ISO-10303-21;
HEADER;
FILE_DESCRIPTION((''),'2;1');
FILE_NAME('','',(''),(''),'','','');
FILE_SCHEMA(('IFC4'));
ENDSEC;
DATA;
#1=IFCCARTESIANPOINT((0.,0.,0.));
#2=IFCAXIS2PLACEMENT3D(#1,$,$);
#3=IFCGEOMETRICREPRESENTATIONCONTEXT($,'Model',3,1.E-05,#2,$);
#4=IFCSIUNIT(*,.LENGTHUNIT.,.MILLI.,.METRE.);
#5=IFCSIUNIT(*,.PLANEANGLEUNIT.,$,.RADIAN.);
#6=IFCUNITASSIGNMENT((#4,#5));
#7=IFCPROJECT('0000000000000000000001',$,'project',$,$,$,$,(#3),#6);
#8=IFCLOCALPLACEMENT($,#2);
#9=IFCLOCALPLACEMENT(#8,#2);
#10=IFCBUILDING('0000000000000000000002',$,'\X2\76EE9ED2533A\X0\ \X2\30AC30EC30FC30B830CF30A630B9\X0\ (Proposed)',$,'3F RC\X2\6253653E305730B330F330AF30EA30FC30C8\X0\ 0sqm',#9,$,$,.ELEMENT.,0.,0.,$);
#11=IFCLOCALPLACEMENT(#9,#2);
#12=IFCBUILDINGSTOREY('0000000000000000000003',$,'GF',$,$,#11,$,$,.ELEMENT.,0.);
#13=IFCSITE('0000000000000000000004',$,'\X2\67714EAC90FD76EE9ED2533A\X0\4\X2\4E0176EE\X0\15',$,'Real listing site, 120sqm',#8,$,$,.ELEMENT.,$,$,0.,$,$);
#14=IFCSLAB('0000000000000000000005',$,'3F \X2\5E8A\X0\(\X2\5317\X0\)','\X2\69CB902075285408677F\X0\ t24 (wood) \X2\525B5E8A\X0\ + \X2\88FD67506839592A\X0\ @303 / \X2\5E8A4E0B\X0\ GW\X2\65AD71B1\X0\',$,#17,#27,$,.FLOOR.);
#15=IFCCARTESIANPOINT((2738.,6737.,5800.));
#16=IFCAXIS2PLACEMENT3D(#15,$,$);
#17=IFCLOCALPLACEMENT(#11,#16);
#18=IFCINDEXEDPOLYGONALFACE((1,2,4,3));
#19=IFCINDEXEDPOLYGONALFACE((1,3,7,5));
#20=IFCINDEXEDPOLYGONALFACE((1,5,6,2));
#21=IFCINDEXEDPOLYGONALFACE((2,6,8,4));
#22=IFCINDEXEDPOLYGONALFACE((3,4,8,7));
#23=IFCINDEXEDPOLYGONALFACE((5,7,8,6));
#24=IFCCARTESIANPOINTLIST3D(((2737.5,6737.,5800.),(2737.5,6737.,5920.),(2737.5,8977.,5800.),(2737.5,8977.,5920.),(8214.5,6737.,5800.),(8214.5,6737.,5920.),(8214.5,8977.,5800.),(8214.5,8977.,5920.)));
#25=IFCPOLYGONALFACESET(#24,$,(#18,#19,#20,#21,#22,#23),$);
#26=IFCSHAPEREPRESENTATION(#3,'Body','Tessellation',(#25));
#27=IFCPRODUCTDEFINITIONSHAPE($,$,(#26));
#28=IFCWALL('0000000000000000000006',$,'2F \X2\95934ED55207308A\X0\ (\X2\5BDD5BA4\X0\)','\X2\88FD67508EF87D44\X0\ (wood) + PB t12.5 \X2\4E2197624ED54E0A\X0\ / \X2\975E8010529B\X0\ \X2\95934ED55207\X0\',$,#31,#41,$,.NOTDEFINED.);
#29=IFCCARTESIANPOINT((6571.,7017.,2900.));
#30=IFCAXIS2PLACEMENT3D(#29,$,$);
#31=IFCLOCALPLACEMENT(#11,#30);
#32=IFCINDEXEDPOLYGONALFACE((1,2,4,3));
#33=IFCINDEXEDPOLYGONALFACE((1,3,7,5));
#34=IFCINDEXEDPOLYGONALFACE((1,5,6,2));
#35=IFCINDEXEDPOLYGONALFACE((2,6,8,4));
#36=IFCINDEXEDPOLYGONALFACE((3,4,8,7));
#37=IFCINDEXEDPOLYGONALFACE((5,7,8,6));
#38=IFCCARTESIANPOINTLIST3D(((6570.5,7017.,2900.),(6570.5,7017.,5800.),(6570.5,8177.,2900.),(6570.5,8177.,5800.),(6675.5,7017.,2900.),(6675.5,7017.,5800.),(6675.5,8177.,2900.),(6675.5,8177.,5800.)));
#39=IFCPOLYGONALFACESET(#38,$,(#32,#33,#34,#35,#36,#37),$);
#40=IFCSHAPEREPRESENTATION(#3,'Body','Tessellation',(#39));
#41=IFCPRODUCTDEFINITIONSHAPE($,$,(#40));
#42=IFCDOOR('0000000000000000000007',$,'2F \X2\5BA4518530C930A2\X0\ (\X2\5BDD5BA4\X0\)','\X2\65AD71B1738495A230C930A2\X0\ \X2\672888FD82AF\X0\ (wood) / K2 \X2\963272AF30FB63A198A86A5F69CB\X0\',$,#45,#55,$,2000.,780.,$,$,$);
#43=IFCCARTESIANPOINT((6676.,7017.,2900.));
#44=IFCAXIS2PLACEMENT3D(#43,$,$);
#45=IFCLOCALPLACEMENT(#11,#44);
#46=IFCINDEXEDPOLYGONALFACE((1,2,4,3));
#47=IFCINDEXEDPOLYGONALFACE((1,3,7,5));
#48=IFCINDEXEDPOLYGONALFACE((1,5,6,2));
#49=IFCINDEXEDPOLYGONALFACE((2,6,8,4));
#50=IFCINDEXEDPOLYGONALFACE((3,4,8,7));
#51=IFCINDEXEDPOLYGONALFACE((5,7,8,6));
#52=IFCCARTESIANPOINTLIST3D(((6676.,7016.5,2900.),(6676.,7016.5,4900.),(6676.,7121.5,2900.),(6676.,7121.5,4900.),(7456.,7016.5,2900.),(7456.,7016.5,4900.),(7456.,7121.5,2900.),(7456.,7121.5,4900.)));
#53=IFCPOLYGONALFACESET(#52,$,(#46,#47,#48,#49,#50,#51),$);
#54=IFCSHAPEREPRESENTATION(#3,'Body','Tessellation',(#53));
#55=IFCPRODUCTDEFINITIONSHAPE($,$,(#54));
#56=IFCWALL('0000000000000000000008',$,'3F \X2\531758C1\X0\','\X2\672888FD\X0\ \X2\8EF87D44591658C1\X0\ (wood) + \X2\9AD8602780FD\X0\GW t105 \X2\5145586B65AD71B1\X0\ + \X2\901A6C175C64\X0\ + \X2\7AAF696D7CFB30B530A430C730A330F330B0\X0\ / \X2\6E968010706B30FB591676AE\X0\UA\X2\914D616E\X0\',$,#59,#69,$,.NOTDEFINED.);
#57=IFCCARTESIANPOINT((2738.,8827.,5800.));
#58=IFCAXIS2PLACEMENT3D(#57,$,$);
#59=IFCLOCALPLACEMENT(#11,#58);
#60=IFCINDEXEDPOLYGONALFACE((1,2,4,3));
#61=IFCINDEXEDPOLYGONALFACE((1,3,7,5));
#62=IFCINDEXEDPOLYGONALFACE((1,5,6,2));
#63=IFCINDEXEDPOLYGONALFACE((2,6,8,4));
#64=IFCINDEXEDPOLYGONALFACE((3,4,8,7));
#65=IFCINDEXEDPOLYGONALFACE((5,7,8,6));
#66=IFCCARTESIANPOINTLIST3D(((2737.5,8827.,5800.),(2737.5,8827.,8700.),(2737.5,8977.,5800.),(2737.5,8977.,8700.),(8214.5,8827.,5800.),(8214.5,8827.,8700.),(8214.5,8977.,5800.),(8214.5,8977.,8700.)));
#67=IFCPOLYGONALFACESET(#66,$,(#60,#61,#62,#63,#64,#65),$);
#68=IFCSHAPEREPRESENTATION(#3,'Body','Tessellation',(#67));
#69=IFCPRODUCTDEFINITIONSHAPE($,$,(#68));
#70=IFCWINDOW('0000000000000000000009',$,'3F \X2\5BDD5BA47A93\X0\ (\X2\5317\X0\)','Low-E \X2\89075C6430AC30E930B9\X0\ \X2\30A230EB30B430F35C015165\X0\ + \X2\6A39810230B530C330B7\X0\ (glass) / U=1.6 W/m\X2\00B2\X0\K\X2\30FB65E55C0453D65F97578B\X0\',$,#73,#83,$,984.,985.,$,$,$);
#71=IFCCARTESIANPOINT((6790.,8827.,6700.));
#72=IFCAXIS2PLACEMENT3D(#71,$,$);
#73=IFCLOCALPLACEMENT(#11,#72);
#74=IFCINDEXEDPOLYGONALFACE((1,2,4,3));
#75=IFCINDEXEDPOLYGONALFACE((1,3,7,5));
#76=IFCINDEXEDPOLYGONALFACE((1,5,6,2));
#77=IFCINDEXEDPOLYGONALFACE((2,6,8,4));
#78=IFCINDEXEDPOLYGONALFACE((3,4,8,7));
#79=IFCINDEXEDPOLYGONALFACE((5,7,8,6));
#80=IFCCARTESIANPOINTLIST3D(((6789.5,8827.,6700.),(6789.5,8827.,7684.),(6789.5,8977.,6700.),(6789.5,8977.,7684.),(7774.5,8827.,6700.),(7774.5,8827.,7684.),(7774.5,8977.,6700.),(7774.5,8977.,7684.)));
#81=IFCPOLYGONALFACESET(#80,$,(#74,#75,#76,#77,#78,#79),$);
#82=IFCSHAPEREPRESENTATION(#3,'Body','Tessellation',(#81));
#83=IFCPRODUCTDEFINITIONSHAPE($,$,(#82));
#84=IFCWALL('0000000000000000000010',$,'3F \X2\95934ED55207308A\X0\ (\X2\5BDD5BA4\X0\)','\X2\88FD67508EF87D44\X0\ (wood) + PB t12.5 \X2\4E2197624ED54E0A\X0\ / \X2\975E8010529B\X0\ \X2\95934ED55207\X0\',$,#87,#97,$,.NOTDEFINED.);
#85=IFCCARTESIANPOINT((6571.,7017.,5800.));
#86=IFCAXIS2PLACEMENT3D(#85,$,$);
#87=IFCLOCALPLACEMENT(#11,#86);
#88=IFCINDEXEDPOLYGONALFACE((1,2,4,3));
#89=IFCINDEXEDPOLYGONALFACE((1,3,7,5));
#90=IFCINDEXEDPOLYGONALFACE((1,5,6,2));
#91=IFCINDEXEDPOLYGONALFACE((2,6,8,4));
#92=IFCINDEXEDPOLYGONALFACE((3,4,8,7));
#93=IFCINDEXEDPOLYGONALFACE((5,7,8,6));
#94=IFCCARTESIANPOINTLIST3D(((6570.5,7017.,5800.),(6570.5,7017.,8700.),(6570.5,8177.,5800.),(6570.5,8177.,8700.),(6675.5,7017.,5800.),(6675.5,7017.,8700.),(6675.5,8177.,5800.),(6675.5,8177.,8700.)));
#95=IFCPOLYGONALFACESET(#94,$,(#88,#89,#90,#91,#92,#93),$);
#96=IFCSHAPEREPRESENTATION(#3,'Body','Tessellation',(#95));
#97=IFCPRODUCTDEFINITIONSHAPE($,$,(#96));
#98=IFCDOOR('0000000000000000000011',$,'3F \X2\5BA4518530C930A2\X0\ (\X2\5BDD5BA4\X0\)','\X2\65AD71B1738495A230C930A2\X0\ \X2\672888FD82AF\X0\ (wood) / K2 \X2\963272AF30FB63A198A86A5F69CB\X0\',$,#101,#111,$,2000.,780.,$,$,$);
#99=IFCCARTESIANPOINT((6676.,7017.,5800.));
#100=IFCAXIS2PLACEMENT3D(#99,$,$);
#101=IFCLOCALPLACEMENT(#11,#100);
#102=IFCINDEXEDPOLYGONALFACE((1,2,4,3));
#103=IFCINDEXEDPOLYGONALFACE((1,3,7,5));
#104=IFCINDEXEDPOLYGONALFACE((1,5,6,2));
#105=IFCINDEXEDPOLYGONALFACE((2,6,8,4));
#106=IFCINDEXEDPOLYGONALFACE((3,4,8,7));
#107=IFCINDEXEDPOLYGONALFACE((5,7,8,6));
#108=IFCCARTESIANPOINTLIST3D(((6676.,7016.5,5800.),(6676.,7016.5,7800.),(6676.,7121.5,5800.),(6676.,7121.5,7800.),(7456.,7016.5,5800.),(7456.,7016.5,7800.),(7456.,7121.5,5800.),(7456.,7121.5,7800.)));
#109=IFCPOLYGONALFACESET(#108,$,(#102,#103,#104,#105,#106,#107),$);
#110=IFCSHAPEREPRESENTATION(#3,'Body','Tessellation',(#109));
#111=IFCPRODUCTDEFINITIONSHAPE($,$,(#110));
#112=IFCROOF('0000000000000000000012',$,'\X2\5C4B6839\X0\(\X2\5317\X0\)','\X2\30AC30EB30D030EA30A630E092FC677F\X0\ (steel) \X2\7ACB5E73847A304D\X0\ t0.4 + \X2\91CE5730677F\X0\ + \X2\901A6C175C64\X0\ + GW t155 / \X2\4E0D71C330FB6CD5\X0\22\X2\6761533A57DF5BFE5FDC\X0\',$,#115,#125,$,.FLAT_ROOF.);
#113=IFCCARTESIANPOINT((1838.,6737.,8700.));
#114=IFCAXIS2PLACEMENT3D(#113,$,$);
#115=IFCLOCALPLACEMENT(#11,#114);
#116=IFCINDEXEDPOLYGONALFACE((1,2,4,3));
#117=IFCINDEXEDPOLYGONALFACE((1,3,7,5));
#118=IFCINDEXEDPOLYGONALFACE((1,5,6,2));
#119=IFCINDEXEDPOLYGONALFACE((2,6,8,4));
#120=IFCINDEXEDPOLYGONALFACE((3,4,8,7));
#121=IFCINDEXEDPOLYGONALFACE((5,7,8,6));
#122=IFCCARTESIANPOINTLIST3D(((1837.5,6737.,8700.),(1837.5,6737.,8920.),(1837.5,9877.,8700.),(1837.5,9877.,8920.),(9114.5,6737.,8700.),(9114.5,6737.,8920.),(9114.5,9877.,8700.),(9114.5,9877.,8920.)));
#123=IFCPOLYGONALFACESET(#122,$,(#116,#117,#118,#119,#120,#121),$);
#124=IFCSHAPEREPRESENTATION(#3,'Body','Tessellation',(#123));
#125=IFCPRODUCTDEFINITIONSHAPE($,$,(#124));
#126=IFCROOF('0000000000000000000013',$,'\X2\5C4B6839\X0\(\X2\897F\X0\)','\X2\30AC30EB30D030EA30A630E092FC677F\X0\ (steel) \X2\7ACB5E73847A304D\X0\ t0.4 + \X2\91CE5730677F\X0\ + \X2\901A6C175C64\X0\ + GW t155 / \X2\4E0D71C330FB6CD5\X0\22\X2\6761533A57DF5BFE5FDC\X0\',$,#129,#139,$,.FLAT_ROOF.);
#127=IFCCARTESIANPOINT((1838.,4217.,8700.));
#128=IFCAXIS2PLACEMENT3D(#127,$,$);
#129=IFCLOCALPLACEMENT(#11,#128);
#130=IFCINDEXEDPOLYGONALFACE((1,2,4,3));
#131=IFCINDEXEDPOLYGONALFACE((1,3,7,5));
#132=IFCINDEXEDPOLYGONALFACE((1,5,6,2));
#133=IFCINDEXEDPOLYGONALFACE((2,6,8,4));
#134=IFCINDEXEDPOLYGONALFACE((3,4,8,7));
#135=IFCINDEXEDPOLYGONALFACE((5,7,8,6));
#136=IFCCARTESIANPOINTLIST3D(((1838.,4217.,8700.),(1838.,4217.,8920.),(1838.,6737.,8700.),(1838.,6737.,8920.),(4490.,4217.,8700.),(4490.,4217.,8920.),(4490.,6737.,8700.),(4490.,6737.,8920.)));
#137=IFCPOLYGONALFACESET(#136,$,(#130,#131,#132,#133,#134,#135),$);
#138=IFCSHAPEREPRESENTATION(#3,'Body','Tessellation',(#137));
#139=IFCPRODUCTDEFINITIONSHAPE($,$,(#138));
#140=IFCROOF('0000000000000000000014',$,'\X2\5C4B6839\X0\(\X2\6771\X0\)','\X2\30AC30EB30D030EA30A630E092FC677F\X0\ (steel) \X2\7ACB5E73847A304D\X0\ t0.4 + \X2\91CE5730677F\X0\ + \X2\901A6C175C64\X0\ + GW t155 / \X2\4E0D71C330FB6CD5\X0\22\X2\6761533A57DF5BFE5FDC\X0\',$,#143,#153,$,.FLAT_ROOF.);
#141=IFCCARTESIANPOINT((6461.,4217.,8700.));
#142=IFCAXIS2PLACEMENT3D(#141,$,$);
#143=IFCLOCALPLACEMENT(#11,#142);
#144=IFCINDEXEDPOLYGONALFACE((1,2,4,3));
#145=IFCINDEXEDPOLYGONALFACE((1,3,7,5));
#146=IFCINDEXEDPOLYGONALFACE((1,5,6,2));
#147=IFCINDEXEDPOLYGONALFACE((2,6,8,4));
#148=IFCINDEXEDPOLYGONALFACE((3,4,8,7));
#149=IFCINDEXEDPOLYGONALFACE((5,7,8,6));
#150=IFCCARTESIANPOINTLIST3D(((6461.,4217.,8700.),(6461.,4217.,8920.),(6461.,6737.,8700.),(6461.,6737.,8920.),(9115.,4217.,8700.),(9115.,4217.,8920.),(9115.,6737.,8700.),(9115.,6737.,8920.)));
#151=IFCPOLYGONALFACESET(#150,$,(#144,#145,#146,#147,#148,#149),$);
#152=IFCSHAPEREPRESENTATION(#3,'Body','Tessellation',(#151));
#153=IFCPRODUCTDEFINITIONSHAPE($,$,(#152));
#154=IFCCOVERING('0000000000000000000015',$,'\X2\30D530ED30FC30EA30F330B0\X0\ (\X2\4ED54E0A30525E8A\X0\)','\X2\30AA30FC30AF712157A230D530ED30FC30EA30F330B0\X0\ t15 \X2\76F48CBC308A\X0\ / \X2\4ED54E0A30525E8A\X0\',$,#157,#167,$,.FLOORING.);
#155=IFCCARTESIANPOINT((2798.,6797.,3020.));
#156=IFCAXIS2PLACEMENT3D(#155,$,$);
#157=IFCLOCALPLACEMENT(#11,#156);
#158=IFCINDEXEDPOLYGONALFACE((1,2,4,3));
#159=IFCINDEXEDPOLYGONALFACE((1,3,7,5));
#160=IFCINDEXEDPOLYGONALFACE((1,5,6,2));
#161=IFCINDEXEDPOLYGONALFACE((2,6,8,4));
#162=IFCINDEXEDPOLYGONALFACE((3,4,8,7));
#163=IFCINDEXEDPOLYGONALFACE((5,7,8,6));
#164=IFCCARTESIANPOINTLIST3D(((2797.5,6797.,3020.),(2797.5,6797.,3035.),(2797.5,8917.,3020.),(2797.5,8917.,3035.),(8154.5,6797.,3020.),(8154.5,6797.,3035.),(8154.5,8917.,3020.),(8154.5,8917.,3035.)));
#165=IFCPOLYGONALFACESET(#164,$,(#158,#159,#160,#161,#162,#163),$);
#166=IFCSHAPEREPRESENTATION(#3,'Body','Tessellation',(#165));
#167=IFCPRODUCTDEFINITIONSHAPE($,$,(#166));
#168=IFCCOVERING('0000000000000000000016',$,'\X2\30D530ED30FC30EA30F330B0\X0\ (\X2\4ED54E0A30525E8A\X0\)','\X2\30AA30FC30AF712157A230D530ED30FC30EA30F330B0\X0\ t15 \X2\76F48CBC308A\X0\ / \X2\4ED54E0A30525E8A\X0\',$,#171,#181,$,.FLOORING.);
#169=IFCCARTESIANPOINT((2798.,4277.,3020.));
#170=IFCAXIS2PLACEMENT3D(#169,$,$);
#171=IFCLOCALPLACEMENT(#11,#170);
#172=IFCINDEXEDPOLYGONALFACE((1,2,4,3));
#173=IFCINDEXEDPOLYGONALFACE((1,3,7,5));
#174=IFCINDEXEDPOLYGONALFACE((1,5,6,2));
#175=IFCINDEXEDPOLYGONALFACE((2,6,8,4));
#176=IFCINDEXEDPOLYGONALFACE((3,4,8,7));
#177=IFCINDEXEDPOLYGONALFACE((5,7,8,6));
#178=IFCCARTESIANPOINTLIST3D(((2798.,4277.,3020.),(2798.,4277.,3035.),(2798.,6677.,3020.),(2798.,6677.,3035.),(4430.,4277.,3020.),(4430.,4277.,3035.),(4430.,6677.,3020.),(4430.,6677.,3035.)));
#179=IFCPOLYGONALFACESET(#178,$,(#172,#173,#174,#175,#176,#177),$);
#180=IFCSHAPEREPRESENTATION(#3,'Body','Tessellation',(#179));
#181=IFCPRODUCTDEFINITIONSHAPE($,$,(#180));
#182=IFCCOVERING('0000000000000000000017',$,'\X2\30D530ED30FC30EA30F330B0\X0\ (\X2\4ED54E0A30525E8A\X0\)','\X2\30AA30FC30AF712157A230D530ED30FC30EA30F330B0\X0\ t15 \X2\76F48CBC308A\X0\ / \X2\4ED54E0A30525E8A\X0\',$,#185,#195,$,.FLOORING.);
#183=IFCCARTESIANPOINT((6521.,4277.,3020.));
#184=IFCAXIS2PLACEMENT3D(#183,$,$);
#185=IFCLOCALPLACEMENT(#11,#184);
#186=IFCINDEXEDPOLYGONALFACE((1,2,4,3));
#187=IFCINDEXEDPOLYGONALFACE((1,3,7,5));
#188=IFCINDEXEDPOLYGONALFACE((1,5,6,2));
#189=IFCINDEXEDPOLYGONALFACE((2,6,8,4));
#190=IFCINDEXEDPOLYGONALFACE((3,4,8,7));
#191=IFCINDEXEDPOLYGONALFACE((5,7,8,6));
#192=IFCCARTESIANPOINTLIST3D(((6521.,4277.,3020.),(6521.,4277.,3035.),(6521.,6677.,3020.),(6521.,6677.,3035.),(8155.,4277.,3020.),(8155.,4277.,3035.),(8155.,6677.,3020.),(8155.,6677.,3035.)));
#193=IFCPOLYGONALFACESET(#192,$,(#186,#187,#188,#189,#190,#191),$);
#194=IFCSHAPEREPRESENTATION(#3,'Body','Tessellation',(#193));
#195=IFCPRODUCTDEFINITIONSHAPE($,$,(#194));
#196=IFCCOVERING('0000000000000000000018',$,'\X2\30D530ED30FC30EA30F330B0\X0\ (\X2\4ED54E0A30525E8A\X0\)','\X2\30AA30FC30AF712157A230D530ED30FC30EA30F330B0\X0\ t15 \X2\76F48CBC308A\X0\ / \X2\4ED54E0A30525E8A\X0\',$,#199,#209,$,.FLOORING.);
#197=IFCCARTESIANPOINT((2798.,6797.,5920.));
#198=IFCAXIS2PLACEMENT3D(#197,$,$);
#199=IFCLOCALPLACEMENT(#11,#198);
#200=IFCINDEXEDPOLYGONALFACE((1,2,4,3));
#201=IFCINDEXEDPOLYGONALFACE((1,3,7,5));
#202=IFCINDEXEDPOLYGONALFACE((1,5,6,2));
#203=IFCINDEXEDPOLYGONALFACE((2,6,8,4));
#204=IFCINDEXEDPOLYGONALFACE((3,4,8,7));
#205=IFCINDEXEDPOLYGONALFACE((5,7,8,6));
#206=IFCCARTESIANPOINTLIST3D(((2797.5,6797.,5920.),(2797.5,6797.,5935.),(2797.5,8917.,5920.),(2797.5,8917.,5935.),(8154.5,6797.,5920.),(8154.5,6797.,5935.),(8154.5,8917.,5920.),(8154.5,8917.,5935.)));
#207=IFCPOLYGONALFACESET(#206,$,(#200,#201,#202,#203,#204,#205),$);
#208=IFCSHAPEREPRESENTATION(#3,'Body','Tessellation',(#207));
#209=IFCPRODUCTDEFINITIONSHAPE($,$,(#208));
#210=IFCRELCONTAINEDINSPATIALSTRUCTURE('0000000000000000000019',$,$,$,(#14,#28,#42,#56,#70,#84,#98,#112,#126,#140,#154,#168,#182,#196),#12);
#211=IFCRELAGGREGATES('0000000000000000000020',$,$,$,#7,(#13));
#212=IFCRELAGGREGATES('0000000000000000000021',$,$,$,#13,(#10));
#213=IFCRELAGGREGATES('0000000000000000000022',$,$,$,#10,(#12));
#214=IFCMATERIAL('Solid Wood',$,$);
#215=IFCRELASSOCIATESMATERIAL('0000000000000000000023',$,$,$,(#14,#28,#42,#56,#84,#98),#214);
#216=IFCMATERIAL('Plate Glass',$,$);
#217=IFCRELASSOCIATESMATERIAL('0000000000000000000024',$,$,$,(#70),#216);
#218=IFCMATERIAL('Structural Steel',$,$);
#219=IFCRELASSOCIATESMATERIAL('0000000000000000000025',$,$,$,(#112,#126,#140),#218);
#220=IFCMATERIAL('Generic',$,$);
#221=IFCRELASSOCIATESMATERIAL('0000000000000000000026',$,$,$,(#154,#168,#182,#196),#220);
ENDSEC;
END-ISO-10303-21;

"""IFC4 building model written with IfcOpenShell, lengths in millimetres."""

from ifc_helpers import new_model, si_unit, frame, frame_2d, origin, place, context, project, spatial, rectangle, extrude, material, element, fill, save


model = new_model("IFC4")

# Units and contexts
model_context = context("Model", 3, precision=1e-05, world=origin())
ifc_project = project(units=[si_unit("LENGTHUNIT", "METRE", prefix="MILLI"), si_unit("PLANEANGLEUNIT", "RADIAN")], contexts=[model_context])

# Site, building, storey
site_placement = place(None, origin())
site = spatial("IfcSite", under=ifc_project, at=site_placement, Name="東京都目黒区4丁目15", ObjectType="Real listing site, 120sqm", CompositionType="ELEMENT", RefElevation=0.0)
building_placement = place(site_placement, origin())
building = spatial("IfcBuilding", under=site, at=building_placement, Name="目黒区 ガレージハウス (Proposed)", ObjectType="3F RC打放しコンクリート 0sqm", CompositionType="ELEMENT", ElevationOfRefHeight=0.0, ElevationOfTerrain=0.0)
storey_placement = place(building_placement, origin())
storey = spatial("IfcBuildingStorey", under=building, at=storey_placement, Name="GF", CompositionType="ELEMENT", Elevation=0.0)

# Slab
ifc_material_1 = material(Name="Solid Wood")
slab_placement = place(storey_placement, frame((2738.0, 6737.0, 5800.0)))
element("IfcSlab", 1, at=slab_placement, inside=storey, material=ifc_material_1, Name="3F 床(北)", Description="構造用合板 t24 (wood) 剛床 + 製材根太 @303 / 床下 GW断熱", PredefinedType="FLOOR", context=model_context, shape_type="SweptSolid", body=[
    extrude(rectangle(XDim=5477.0, YDim=2240.0, at=frame_2d((2738.0, 1120.0))), frame((2738.0, 6737.0, 5800.0)), (0.0, 0.0, 1.0), 120.0),
])

# Wall
wall_1_placement = place(storey_placement, frame((6571.0, 7017.0, 2900.0)))
element("IfcWall", 2, at=wall_1_placement, inside=storey, material=ifc_material_1, Name="2F 間仕切り (寝室)", Description="製材軸組 (wood) + PB t12.5 両面仕上 / 非耐力 間仕切", PredefinedType="NOTDEFINED", context=model_context, shape_type="SweptSolid", body=[
    extrude(rectangle(XDim=105.0, YDim=1160.0, at=frame_2d((52.0, 580.0))), frame((6571.0, 7017.0, 2900.0)), (0.0, 0.0, 1.0), 2900.0),
])

# Door
door_1_placement = place(storey_placement, frame((6676.0, 7017.0, 2900.0)))
element("IfcDoor", 3, at=door_1_placement, inside=storey, material=ifc_material_1, Name="2F 室内ドア (寝室)", Description="断熱玄関ドア 木製芯 (wood) / K2 防犯・採風機構", OverallHeight=2000.0, OverallWidth=780.0, context=model_context, shape_type="SweptSolid", body=[
    extrude(rectangle(XDim=780.0, YDim=105.0, at=frame_2d((390.0, 52.0))), frame((6676.0, 7017.0, 2900.0)), (0.0, 0.0, 1.0), 2000.0),
])

# Wall, opening, window
wall_2_placement = place(storey_placement, frame((2738.0, 8827.0, 5800.0)))
wall_2 = element("IfcWall", 4, at=wall_2_placement, inside=storey, material=ifc_material_1, Name="3F 北壁", Description="木製 軸組外壁 (wood) + 高性能GW t105 充填断熱 + 通気層 + 窯業系サイディング / 準耐火・外皮UA配慮", PredefinedType="NOTDEFINED", context=model_context, shape_type="SweptSolid", body=[
    extrude(rectangle(XDim=5477.0, YDim=150.0, at=frame_2d((2738.0, 75.0))), frame((2738.0, 8827.0, 5800.0)), (0.0, 0.0, 1.0), 2900.0),
])
opening_1_placement = place(storey_placement, frame((6790.0, 8827.0, 6700.0)))
opening_1 = element("IfcOpeningElement", 5, at=opening_1_placement, cuts=wall_2, PredefinedType="NOTDEFINED", context=model_context, shape_type="SweptSolid", body=[
    extrude(rectangle(XDim=985.0, YDim=150.0, at=frame_2d((492.0, 75.0))), frame((6790.0, 8827.0, 6700.0)), (0.0, 0.0, 1.0), 984.0),
])
ifc_material_2 = material(Name="Plate Glass")
window_1_placement = place(storey_placement, frame((6790.0, 8827.0, 6700.0)))
window_1 = element("IfcWindow", 6, at=window_1_placement, inside=storey, material=ifc_material_2, Name="3F 寝室窓 (北)", Description="Low-E 複層ガラス アルゴン封入 + 樹脂サッシ (glass) / U=1.6 W/m²K・日射取得型", OverallHeight=984.0, OverallWidth=985.0, context=model_context, shape_type="SweptSolid", body=[
    extrude(rectangle(XDim=985.0, YDim=150.0, at=frame_2d((492.0, 75.0))), frame((6790.0, 8827.0, 6700.0)), (0.0, 0.0, 1.0), 984.0),
])
fill(opening_1, window_1)

# Wall
wall_3_placement = place(storey_placement, frame((6571.0, 7017.0, 5800.0)))
element("IfcWall", 7, at=wall_3_placement, inside=storey, material=ifc_material_1, Name="3F 間仕切り (寝室)", Description="製材軸組 (wood) + PB t12.5 両面仕上 / 非耐力 間仕切", PredefinedType="NOTDEFINED", context=model_context, shape_type="SweptSolid", body=[
    extrude(rectangle(XDim=105.0, YDim=1160.0, at=frame_2d((52.0, 580.0))), frame((6571.0, 7017.0, 5800.0)), (0.0, 0.0, 1.0), 2900.0),
])

# Door
door_2_placement = place(storey_placement, frame((6676.0, 7017.0, 5800.0)))
element("IfcDoor", 8, at=door_2_placement, inside=storey, material=ifc_material_1, Name="3F 室内ドア (寝室)", Description="断熱玄関ドア 木製芯 (wood) / K2 防犯・採風機構", OverallHeight=2000.0, OverallWidth=780.0, context=model_context, shape_type="SweptSolid", body=[
    extrude(rectangle(XDim=780.0, YDim=105.0, at=frame_2d((390.0, 52.0))), frame((6676.0, 7017.0, 5800.0)), (0.0, 0.0, 1.0), 2000.0),
])

# Roofs
ifc_material_3 = material(Name="Structural Steel")
for number, where, name in (
    (9, (1838.0, 6737.0, 8700.0), "屋根(北)"),
):
    element("IfcRoof", number, at=place(storey_placement, frame(where)), inside=storey, material=ifc_material_3, Name=name, Description="ガルバリウム鋼板 (steel) 立平葺き t0.4 + 野地板 + 通気層 + GW t155 / 不燃・法22条区域対応", PredefinedType="FLAT_ROOF", context=model_context, shape_type="SweptSolid", body=[
        extrude(rectangle(XDim=7277.0, YDim=3140.0, at=frame_2d((3638.0, 1570.0))), frame((1838.0, 6737.0, 8700.0)), (0.0, 0.0, 1.0), 220.0),
    ])
roof_1_placement = place(storey_placement, frame((1838.0, 4217.0, 8700.0)))
element("IfcRoof", 10, at=roof_1_placement, inside=storey, material=ifc_material_3, Name="屋根(西)", Description="ガルバリウム鋼板 (steel) 立平葺き t0.4 + 野地板 + 通気層 + GW t155 / 不燃・法22条区域対応", PredefinedType="FLAT_ROOF", context=model_context, shape_type="SweptSolid", body=[
    extrude(rectangle(XDim=2652.0, YDim=2520.0, at=frame_2d((1326.0, 1260.0))), frame((1838.0, 4217.0, 8700.0)), (0.0, 0.0, 1.0), 220.0),
])
roof_2_placement = place(storey_placement, frame((6461.0, 4217.0, 8700.0)))
element("IfcRoof", 11, at=roof_2_placement, inside=storey, material=ifc_material_3, Name="屋根(東)", Description="ガルバリウム鋼板 (steel) 立平葺き t0.4 + 野地板 + 通気層 + GW t155 / 不燃・法22条区域対応", PredefinedType="FLAT_ROOF", context=model_context, shape_type="SweptSolid", body=[
    extrude(rectangle(XDim=2654.0, YDim=2520.0, at=frame_2d((1327.0, 1260.0))), frame((6461.0, 4217.0, 8700.0)), (0.0, 0.0, 1.0), 220.0),
])

# Coverings
ifc_material_4 = material(Name="Generic")
covering_1_placement = place(storey_placement, frame((2798.0, 6797.0, 3020.0)))
element("IfcCovering", 12, at=covering_1_placement, inside=storey, material=ifc_material_4, Name="フローリング (仕上げ床)", Description="オーク無垢フローリング t15 直貼り / 仕上げ床", PredefinedType="FLOORING", context=model_context, shape_type="SweptSolid", body=[
    extrude(rectangle(XDim=5357.0, YDim=2120.0, at=frame_2d((2678.0, 1060.0))), frame((2798.0, 6797.0, 3020.0)), (0.0, 0.0, 1.0), 15.0),
])
covering_2_placement = place(storey_placement, frame((2798.0, 4277.0, 3020.0)))
element("IfcCovering", 13, at=covering_2_placement, inside=storey, material=ifc_material_4, Name="フローリング (仕上げ床)", Description="オーク無垢フローリング t15 直貼り / 仕上げ床", PredefinedType="FLOORING", context=model_context, shape_type="SweptSolid", body=[
    extrude(rectangle(XDim=1632.0, YDim=2400.0, at=frame_2d((816.0, 1200.0))), frame((2798.0, 4277.0, 3020.0)), (0.0, 0.0, 1.0), 15.0),
])
covering_3_placement = place(storey_placement, frame((6521.0, 4277.0, 3020.0)))
element("IfcCovering", 14, at=covering_3_placement, inside=storey, material=ifc_material_4, Name="フローリング (仕上げ床)", Description="オーク無垢フローリング t15 直貼り / 仕上げ床", PredefinedType="FLOORING", context=model_context, shape_type="SweptSolid", body=[
    extrude(rectangle(XDim=1634.0, YDim=2400.0, at=frame_2d((817.0, 1200.0))), frame((6521.0, 4277.0, 3020.0)), (0.0, 0.0, 1.0), 15.0),
])
covering_4_placement = place(storey_placement, frame((2798.0, 6797.0, 5920.0)))
element("IfcCovering", 15, at=covering_4_placement, inside=storey, material=ifc_material_4, Name="フローリング (仕上げ床)", Description="オーク無垢フローリング t15 直貼り / 仕上げ床", PredefinedType="FLOORING", context=model_context, shape_type="SweptSolid", body=[
    extrude(rectangle(XDim=5357.0, YDim=2120.0, at=frame_2d((2678.0, 1060.0))), frame((2798.0, 6797.0, 5920.0)), (0.0, 0.0, 1.0), 15.0),
])

save(model, "model.ifc")
